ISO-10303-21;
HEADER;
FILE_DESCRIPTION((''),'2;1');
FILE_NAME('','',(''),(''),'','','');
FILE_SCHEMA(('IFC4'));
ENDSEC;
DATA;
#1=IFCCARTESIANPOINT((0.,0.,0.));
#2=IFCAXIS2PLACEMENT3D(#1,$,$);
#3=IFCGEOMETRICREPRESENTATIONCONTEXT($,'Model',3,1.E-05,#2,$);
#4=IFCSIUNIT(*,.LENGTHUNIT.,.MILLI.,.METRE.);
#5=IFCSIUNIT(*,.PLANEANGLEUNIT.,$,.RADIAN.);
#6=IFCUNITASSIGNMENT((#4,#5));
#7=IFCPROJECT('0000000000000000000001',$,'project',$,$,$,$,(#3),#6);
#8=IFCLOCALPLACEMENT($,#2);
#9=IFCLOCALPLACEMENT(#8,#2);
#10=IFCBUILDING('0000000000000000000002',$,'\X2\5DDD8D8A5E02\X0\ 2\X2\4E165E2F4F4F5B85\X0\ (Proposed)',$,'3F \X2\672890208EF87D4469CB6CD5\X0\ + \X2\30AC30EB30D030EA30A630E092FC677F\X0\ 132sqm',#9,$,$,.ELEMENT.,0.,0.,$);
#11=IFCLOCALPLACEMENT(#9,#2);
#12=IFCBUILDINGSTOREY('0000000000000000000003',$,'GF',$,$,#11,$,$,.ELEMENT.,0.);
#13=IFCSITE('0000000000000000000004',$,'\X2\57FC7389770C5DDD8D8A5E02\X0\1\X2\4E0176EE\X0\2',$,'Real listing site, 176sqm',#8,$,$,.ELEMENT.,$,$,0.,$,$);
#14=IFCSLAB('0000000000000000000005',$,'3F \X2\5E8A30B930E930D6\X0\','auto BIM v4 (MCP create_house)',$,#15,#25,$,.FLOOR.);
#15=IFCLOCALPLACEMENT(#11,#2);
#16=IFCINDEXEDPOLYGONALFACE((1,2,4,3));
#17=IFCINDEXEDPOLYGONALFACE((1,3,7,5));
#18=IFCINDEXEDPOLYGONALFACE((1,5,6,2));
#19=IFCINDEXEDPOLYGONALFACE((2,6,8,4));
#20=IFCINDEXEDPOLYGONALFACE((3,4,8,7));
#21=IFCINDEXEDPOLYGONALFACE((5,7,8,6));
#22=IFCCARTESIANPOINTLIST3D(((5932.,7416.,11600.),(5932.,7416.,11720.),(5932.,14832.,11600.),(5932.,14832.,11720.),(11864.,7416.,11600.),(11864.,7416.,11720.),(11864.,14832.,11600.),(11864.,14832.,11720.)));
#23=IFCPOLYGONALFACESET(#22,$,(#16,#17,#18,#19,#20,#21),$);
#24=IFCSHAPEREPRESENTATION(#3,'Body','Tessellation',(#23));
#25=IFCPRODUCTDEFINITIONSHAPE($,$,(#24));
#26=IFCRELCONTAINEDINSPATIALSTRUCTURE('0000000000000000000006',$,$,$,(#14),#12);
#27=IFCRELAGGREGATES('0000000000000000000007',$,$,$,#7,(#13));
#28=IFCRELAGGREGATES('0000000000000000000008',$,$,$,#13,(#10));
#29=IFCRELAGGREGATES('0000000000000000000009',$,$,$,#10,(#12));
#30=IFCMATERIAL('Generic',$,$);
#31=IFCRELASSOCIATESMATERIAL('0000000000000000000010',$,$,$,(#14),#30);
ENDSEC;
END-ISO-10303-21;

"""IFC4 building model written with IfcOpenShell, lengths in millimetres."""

from ifc_helpers import new_model, si_unit, frame, frame_2d, origin, place, context, project, spatial, rectangle, extrude, material, element, save


model = new_model("IFC4")

# Units and contexts
model_context = context("Model", 3, precision=1e-05, world=origin())
ifc_project = project(units=[si_unit("LENGTHUNIT", "METRE", prefix="MILLI"), si_unit("PLANEANGLEUNIT", "RADIAN")], contexts=[model_context])

# Site, building, storey
site_placement = place(None, origin())
site = spatial("IfcSite", under=ifc_project, at=site_placement, Name="埼玉県川越市1丁目2", ObjectType="Real listing site, 176sqm", CompositionType="ELEMENT", RefElevation=0.0)
building_placement = place(site_placement, origin())
building = spatial("IfcBuilding", under=site, at=building_placement, Name="川越市 2世帯住宅 (Proposed)", ObjectType="3F 木造軸組構法 + ガルバリウム鋼板 132sqm", CompositionType="ELEMENT", ElevationOfRefHeight=0.0, ElevationOfTerrain=0.0)
storey_placement = place(building_placement, origin())
storey = spatial("IfcBuildingStorey", under=building, at=storey_placement, Name="GF", CompositionType="ELEMENT", Elevation=0.0)

# Slab
ifc_material = material(Name="Generic")
slab_placement = place(storey_placement, frame((2966.0, 3708.0, 5800.0)))
element("IfcSlab", 1, at=slab_placement, inside=storey, material=ifc_material, Name="3F 床スラブ", Description="auto BIM v4 (MCP create_house)", PredefinedType="FLOOR", context=model_context, shape_type="SweptSolid", body=[
    extrude(rectangle(XDim=5932.0, YDim=7416.0, at=frame_2d((2966.0, 3708.0))), frame((2966.0, 3708.0, 5800.0)), (0.0, 0.0, 1.0), 120.0),
])

save(model, "model.ifc")
